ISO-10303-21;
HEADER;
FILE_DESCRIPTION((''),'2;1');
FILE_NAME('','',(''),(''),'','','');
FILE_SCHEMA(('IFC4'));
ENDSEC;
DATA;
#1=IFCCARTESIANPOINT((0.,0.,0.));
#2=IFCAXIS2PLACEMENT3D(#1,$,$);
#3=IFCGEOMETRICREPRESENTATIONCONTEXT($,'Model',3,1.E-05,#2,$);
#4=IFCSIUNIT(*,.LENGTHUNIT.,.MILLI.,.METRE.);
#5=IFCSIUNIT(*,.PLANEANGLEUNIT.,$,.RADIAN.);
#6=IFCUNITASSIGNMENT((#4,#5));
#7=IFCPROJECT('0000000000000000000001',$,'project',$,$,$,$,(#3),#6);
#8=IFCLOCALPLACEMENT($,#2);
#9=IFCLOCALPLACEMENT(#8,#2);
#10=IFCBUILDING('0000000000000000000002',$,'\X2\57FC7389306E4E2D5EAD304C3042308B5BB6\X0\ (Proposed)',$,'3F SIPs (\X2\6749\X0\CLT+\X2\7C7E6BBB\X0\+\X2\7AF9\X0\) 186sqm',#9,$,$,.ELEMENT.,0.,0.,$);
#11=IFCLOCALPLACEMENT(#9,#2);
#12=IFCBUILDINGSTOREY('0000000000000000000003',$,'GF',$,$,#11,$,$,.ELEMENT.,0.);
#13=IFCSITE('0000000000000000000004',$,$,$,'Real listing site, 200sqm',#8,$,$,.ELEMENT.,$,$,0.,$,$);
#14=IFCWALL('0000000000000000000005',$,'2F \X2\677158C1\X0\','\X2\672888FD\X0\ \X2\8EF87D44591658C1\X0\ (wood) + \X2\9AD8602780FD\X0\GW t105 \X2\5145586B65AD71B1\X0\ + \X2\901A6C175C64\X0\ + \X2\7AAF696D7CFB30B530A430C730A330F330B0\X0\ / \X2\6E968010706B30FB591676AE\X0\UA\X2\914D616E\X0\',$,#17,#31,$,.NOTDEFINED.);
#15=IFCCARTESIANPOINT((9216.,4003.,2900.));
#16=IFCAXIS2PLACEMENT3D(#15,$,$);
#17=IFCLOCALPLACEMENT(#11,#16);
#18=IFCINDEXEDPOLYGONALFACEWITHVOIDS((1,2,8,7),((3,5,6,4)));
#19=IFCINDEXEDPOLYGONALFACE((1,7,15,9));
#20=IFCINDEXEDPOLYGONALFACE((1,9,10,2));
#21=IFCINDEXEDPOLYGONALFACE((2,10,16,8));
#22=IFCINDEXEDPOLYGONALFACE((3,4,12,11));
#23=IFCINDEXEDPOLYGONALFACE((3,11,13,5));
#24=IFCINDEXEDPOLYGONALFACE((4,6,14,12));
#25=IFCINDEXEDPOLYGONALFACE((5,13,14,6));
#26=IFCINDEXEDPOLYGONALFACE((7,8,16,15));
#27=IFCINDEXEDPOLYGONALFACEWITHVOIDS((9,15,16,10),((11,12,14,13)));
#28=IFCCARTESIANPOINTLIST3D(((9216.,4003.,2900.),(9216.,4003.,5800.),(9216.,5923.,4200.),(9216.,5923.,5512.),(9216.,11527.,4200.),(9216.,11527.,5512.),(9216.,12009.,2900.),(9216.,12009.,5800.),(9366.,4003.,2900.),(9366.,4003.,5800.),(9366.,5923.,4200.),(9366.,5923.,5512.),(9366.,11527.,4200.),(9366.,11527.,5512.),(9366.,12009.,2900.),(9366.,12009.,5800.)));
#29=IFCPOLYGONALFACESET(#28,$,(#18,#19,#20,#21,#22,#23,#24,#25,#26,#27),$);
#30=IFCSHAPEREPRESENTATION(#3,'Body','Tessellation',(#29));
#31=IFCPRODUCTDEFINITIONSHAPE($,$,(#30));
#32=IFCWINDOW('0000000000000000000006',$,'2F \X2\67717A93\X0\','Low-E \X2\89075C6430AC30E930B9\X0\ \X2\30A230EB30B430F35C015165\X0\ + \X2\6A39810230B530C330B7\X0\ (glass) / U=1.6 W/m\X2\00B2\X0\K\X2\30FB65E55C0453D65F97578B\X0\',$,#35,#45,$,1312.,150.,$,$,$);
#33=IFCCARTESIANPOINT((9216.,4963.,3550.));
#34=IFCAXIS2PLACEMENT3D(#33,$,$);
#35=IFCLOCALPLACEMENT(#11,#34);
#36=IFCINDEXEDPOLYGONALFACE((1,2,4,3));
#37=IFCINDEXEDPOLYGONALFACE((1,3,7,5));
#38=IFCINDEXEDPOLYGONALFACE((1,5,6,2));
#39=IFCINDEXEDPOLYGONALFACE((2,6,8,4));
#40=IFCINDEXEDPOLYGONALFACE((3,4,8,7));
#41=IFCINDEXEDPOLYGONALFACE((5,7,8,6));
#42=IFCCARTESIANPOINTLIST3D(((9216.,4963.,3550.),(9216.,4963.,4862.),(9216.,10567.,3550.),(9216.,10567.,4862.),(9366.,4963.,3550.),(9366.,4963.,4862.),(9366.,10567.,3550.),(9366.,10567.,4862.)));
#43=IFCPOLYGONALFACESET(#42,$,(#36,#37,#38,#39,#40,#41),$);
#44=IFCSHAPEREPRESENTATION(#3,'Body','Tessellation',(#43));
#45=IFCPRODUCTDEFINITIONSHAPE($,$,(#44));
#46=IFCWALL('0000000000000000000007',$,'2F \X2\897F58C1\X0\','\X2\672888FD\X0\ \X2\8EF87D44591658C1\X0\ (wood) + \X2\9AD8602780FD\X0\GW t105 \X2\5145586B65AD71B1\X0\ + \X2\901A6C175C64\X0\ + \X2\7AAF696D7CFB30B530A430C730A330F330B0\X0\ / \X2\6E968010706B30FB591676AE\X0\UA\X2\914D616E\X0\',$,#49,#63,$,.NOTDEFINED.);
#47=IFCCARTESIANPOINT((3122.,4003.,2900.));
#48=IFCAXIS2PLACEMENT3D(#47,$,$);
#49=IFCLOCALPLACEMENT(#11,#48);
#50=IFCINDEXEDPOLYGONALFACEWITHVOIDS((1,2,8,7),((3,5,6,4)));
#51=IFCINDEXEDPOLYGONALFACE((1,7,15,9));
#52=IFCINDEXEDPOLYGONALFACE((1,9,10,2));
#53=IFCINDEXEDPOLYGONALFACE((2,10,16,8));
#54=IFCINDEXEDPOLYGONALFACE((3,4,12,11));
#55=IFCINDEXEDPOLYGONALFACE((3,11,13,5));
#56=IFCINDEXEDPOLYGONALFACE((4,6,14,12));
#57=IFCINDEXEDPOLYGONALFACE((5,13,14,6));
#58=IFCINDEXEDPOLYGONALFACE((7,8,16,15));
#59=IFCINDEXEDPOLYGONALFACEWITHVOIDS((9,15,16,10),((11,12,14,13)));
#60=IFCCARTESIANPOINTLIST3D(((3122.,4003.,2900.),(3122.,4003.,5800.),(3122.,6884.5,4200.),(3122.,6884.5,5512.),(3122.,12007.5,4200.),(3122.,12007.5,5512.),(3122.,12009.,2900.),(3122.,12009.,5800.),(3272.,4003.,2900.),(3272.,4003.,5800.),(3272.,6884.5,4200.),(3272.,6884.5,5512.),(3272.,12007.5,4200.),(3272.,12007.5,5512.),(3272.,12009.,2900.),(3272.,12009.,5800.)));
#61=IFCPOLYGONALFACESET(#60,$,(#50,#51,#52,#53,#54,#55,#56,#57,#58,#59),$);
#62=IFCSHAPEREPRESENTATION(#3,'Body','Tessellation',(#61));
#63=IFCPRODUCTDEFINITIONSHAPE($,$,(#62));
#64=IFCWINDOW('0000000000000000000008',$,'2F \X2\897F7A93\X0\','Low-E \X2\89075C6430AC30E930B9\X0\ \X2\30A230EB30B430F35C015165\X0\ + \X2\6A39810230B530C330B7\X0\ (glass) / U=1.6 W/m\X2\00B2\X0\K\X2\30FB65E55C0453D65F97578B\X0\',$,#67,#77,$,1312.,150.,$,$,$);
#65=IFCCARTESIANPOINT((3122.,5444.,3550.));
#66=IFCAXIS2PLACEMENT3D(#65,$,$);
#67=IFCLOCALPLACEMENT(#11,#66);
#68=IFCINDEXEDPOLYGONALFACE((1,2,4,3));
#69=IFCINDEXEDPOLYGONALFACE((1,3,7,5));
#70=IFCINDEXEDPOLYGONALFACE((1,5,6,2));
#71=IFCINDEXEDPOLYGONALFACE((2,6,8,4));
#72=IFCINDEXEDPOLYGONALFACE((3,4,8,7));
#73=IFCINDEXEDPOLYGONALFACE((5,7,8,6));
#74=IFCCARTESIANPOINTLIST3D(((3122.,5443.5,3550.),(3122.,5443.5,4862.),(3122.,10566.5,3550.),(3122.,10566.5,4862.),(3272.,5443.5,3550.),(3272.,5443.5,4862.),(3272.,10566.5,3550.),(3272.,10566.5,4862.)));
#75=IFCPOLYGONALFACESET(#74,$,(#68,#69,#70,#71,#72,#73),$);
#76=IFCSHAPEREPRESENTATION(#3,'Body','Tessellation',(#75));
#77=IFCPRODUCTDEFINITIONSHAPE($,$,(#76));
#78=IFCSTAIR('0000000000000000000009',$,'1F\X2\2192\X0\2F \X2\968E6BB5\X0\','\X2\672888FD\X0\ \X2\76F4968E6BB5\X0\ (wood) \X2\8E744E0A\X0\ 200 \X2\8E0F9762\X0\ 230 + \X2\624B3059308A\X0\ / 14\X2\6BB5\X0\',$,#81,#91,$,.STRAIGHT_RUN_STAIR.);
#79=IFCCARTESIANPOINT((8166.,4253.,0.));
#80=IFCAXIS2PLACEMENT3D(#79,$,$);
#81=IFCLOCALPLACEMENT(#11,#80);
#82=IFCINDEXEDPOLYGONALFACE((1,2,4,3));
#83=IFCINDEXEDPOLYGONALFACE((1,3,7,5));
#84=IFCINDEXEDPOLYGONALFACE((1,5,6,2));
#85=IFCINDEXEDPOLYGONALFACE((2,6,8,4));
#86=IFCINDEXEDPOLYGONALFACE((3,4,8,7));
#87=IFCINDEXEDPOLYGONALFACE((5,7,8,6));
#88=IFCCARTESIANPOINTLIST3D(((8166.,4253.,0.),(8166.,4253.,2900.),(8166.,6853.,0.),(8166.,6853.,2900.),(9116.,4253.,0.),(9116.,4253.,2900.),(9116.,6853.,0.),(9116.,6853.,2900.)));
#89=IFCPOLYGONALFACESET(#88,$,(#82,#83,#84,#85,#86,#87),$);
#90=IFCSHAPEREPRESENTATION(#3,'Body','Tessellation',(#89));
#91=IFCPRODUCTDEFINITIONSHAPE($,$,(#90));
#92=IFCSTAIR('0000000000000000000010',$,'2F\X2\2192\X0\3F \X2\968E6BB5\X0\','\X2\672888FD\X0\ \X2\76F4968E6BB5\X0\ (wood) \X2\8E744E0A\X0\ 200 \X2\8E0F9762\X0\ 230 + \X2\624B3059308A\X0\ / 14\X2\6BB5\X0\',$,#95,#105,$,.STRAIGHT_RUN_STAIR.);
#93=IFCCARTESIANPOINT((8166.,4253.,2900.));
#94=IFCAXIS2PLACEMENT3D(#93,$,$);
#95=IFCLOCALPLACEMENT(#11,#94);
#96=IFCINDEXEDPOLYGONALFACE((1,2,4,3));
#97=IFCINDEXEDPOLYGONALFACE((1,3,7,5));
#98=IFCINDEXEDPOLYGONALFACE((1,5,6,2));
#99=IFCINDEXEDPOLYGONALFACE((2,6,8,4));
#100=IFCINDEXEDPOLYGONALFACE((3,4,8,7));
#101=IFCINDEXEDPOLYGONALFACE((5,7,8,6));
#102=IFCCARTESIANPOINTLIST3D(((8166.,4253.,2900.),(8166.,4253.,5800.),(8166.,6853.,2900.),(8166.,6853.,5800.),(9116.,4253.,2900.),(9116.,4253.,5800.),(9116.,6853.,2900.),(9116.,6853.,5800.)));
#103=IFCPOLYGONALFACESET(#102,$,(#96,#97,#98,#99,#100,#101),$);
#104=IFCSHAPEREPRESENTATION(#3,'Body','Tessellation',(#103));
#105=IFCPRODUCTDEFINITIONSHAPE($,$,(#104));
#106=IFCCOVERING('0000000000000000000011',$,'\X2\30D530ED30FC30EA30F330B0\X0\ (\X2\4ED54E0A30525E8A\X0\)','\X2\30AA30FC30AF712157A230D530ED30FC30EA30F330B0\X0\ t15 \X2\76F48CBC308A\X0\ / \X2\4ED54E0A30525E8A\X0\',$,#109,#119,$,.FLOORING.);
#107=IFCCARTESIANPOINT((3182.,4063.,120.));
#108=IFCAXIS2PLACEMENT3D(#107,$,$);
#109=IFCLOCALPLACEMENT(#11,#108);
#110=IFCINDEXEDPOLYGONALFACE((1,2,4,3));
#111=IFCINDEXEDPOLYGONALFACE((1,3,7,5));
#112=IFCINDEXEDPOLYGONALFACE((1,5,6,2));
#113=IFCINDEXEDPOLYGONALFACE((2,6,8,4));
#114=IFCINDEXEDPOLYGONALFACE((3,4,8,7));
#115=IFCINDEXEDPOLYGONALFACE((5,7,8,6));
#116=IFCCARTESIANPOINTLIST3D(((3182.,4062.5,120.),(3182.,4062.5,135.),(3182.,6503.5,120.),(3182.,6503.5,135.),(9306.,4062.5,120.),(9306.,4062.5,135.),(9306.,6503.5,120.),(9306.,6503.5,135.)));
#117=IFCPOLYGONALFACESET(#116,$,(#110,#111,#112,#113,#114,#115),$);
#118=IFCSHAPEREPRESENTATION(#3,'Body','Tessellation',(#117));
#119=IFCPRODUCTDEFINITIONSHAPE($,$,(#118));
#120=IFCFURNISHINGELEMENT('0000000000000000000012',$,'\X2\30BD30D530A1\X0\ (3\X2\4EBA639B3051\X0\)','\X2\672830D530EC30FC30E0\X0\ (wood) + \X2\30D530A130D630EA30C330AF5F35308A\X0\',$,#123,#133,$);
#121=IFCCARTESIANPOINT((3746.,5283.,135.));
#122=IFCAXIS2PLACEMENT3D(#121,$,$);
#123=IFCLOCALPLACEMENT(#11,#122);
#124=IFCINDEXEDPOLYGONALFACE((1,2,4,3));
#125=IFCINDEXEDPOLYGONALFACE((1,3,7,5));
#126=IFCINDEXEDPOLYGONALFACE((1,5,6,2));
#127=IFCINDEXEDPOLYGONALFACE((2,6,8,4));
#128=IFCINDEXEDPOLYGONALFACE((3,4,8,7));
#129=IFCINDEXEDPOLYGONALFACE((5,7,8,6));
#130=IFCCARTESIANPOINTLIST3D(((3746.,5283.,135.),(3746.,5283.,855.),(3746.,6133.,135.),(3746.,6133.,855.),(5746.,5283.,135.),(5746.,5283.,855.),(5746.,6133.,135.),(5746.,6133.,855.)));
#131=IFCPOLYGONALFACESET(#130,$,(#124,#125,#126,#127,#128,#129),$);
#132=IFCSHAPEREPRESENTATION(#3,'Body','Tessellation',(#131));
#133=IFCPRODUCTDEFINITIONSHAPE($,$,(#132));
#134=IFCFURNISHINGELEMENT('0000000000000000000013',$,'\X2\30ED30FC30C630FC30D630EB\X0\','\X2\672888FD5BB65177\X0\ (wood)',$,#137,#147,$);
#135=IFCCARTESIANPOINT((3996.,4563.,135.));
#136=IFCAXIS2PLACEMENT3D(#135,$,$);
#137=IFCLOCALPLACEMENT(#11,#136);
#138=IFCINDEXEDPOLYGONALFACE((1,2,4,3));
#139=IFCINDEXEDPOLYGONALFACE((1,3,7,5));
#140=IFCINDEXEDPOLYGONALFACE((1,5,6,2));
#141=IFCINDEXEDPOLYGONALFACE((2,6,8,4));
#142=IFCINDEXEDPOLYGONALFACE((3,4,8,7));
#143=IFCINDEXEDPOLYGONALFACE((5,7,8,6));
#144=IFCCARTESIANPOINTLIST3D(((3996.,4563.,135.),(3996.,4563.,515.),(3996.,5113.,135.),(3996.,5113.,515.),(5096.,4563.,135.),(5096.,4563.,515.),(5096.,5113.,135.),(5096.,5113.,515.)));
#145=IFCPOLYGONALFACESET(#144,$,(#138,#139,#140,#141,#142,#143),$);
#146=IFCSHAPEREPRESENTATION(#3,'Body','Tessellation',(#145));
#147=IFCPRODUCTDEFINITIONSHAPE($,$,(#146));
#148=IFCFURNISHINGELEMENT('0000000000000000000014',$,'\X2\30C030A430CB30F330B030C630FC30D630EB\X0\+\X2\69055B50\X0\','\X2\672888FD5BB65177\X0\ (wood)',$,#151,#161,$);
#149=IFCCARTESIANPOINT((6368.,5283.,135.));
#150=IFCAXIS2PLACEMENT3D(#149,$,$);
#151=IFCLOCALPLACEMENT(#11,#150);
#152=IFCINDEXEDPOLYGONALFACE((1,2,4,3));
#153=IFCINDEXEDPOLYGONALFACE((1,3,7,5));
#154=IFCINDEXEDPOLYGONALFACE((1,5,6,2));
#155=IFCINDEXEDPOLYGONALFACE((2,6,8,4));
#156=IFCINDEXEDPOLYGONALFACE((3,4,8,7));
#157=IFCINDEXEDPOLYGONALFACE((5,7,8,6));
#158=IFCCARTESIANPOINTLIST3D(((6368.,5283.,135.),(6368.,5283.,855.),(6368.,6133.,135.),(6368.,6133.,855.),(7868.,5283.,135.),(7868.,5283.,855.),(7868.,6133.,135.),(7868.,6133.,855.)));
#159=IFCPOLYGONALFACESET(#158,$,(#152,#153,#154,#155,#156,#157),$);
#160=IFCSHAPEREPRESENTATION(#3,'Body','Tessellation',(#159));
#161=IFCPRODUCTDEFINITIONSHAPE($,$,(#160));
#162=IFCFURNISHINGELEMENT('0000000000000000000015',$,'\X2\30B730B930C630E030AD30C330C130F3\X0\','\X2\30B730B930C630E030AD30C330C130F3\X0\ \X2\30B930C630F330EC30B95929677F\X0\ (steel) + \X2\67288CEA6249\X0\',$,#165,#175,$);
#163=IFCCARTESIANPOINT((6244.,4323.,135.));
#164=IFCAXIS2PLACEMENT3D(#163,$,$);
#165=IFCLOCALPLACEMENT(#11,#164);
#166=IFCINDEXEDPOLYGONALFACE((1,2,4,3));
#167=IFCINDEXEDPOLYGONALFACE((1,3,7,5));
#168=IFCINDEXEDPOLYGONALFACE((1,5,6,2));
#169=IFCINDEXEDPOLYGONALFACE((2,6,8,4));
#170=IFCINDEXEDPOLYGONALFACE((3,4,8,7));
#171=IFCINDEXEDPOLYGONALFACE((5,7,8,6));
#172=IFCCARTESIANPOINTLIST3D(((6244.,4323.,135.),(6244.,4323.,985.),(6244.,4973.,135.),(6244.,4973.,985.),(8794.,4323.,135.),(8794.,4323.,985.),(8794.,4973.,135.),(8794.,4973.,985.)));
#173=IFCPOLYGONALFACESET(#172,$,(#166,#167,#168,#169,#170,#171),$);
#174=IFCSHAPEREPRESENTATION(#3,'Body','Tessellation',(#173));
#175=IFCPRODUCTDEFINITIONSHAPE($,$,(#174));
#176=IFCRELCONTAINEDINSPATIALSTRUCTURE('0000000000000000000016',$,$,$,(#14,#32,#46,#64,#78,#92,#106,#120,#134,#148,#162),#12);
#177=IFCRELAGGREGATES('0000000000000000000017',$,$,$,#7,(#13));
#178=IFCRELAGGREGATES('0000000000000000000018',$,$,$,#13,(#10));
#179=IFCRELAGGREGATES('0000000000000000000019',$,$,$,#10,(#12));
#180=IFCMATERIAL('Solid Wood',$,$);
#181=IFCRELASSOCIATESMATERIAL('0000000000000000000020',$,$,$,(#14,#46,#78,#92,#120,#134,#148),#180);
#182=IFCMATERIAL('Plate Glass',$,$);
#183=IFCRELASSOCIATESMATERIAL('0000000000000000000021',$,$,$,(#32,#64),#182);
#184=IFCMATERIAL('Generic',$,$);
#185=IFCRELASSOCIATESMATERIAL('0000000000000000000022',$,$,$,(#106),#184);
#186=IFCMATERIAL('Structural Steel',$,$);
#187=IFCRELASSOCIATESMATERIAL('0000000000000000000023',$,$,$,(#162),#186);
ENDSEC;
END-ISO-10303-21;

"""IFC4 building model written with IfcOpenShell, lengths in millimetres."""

from ifc_helpers import new_model, si_unit, frame, frame_2d, origin, place, context, project, spatial, rectangle, extrude, material, element, fill, save


model = new_model("IFC4")

# Units and contexts
model_context = context("Model", 3, precision=1e-05, world=origin())
ifc_project = project(units=[si_unit("LENGTHUNIT", "METRE", prefix="MILLI"), si_unit("PLANEANGLEUNIT", "RADIAN")], contexts=[model_context])

# Site, building, storey
site_placement = place(None, origin())
site = spatial("IfcSite", under=ifc_project, at=site_placement, ObjectType="Real listing site, 200sqm", CompositionType="ELEMENT", RefElevation=0.0)
building_placement = place(site_placement, origin())
building = spatial("IfcBuilding", under=site, at=building_placement, Name="埼玉の中庭がある家 (Proposed)", ObjectType="3F SIPs (杉CLT+籾殻+竹) 186sqm", CompositionType="ELEMENT", ElevationOfRefHeight=0.0, ElevationOfTerrain=0.0)
storey_placement = place(building_placement, origin())
storey = spatial("IfcBuildingStorey", under=building, at=storey_placement, Name="GF", CompositionType="ELEMENT", Elevation=0.0)

# Shared definitions
ifc_material_1 = material(Name="Solid Wood")

# Shared definitions
ifc_material_2 = material(Name="Plate Glass")

# Walls, openings, windows
wall_1_placement = place(storey_placement, frame((9216.0, 4003.0, 2900.0)))
wall_1 = element("IfcWall", 1, at=wall_1_placement, inside=storey, material=ifc_material_1, Name="2F 東壁", Description="木製 軸組外壁 (wood) + 高性能GW t105 充填断熱 + 通気層 + 窯業系サイディング / 準耐火・外皮UA配慮", PredefinedType="NOTDEFINED", context=model_context, shape_type="SweptSolid", body=[
    extrude(rectangle(XDim=150.0, YDim=8006.0, at=frame_2d((75.0, 4003.0))), frame((9216.0, 4003.0, 2900.0)), (0.0, 0.0, 1.0), 2900.0),
])
opening_1_placement = place(storey_placement, frame((9216.0, 4963.0, 3550.0)))
opening_1 = element("IfcOpeningElement", 2, at=opening_1_placement, cuts=wall_1, PredefinedType="NOTDEFINED", context=model_context, shape_type="SweptSolid", body=[
    extrude(rectangle(XDim=150.0, YDim=5604.0, at=frame_2d((75.0, 2802.0))), frame((9216.0, 4963.0, 3550.0)), (0.0, 0.0, 1.0), 1312.0),
])
window_1_placement = place(storey_placement, frame((9216.0, 4963.0, 3550.0)))
window_1 = element("IfcWindow", 3, at=window_1_placement, inside=storey, material=ifc_material_2, Name="2F 東窓", Description="Low-E 複層ガラス アルゴン封入 + 樹脂サッシ (glass) / U=1.6 W/m²K・日射取得型", OverallHeight=1312.0, OverallWidth=150.0, context=model_context, shape_type="SweptSolid", body=[
    extrude(rectangle(XDim=150.0, YDim=5604.0, at=frame_2d((75.0, 2802.0))), frame((9216.0, 4963.0, 3550.0)), (0.0, 0.0, 1.0), 1312.0),
])
fill(opening_1, window_1)
wall_2_placement = place(storey_placement, frame((3122.0, 4003.0, 2900.0)))
wall_2 = element("IfcWall", 4, at=wall_2_placement, inside=storey, material=ifc_material_1, Name="2F 西壁", Description="木製 軸組外壁 (wood) + 高性能GW t105 充填断熱 + 通気層 + 窯業系サイディング / 準耐火・外皮UA配慮", PredefinedType="NOTDEFINED", context=model_context, shape_type="SweptSolid", body=[
    extrude(rectangle(XDim=150.0, YDim=8006.0, at=frame_2d((75.0, 4003.0))), frame((3122.0, 4003.0, 2900.0)), (0.0, 0.0, 1.0), 2900.0),
])
opening_2_placement = place(storey_placement, frame((3122.0, 5444.0, 3550.0)))
opening_2 = element("IfcOpeningElement", 5, at=opening_2_placement, cuts=wall_2, PredefinedType="NOTDEFINED", context=model_context, shape_type="SweptSolid", body=[
    extrude(rectangle(XDim=150.0, YDim=5123.0, at=frame_2d((75.0, 2561.0))), frame((3122.0, 5444.0, 3550.0)), (0.0, 0.0, 1.0), 1312.0),
])
window_2_placement = place(storey_placement, frame((3122.0, 5444.0, 3550.0)))
window_2 = element("IfcWindow", 6, at=window_2_placement, inside=storey, material=ifc_material_2, Name="2F 西窓", Description="Low-E 複層ガラス アルゴン封入 + 樹脂サッシ (glass) / U=1.6 W/m²K・日射取得型", OverallHeight=1312.0, OverallWidth=150.0, context=model_context, shape_type="SweptSolid", body=[
    extrude(rectangle(XDim=150.0, YDim=5123.0, at=frame_2d((75.0, 2561.0))), frame((3122.0, 5444.0, 3550.0)), (0.0, 0.0, 1.0), 1312.0),
])
fill(opening_2, window_2)

# Stairs
stair_1_placement = place(storey_placement, frame((8166.0, 4253.0, 0.0)))
element("IfcStair", 7, at=stair_1_placement, inside=storey, material=ifc_material_1, Name="1F→2F 階段", Description="木製 直階段 (wood) 蹴上 200 踏面 230 + 手すり / 14段", PredefinedType="STRAIGHT_RUN_STAIR", context=model_context, shape_type="SweptSolid", body=[
    extrude(rectangle(XDim=950.0, YDim=2600.0, at=frame_2d((475.0, 1300.0))), frame((8166.0, 4253.0, 0.0)), (0.0, 0.0, 1.0), 2900.0),
])
stair_2_placement = place(storey_placement, frame((8166.0, 4253.0, 2900.0)))
element("IfcStair", 8, at=stair_2_placement, inside=storey, material=ifc_material_1, Name="2F→3F 階段", Description="木製 直階段 (wood) 蹴上 200 踏面 230 + 手すり / 14段", PredefinedType="STRAIGHT_RUN_STAIR", context=model_context, shape_type="SweptSolid", body=[
    extrude(rectangle(XDim=950.0, YDim=2600.0, at=frame_2d((475.0, 1300.0))), frame((8166.0, 4253.0, 2900.0)), (0.0, 0.0, 1.0), 2900.0),
])

# Covering
ifc_material_3 = material(Name="Generic")
covering_placement = place(storey_placement, frame((3182.0, 4063.0, 120.0)))
element("IfcCovering", 9, at=covering_placement, inside=storey, material=ifc_material_3, Name="フローリング (仕上げ床)", Description="オーク無垢フローリング t15 直貼り / 仕上げ床", PredefinedType="FLOORING", context=model_context, shape_type="SweptSolid", body=[
    extrude(rectangle(XDim=6124.0, YDim=2441.0, at=frame_2d((3062.0, 1220.0))), frame((3182.0, 4063.0, 120.0)), (0.0, 0.0, 1.0), 15.0),
])

# Furnishing elements
furnishing_1_placement = place(storey_placement, frame((3746.0, 5283.0, 135.0)))
element("IfcFurnishingElement", 10, at=furnishing_1_placement, inside=storey, material=ifc_material_1, Name="ソファ (3人掛け)", Description="木フレーム (wood) + ファブリック張り", context=model_context, shape_type="SweptSolid", body=[
    extrude(rectangle(XDim=2000.0, YDim=850.0, at=frame_2d((1000.0, 425.0))), frame((3746.0, 5283.0, 135.0)), (0.0, 0.0, 1.0), 720.0),
])
furnishing_2_placement = place(storey_placement, frame((3996.0, 4563.0, 135.0)))
element("IfcFurnishingElement", 11, at=furnishing_2_placement, inside=storey, material=ifc_material_1, Name="ローテーブル", Description="木製家具 (wood)", context=model_context, shape_type="SweptSolid", body=[
    extrude(rectangle(XDim=1100.0, YDim=550.0, at=frame_2d((550.0, 275.0))), frame((3996.0, 4563.0, 135.0)), (0.0, 0.0, 1.0), 380.0),
])
furnishing_3_placement = place(storey_placement, frame((6368.0, 5283.0, 135.0)))
element("IfcFurnishingElement", 12, at=furnishing_3_placement, inside=storey, material=ifc_material_1, Name="ダイニングテーブル+椅子", Description="木製家具 (wood)", context=model_context, shape_type="SweptSolid", body=[
    extrude(rectangle(XDim=1500.0, YDim=850.0, at=frame_2d((750.0, 425.0))), frame((6368.0, 5283.0, 135.0)), (0.0, 0.0, 1.0), 720.0),
])
ifc_material_4 = material(Name="Structural Steel")
furnishing_4_placement = place(storey_placement, frame((6244.0, 4323.0, 135.0)))
element("IfcFurnishingElement", 13, at=furnishing_4_placement, inside=storey, material=ifc_material_4, Name="システムキッチン", Description="システムキッチン ステンレス天板 (steel) + 木質扉", context=model_context, shape_type="SweptSolid", body=[
    extrude(rectangle(XDim=2550.0, YDim=650.0, at=frame_2d((1275.0, 325.0))), frame((6244.0, 4323.0, 135.0)), (0.0, 0.0, 1.0), 850.0),
])

save(model, "model.ifc")
